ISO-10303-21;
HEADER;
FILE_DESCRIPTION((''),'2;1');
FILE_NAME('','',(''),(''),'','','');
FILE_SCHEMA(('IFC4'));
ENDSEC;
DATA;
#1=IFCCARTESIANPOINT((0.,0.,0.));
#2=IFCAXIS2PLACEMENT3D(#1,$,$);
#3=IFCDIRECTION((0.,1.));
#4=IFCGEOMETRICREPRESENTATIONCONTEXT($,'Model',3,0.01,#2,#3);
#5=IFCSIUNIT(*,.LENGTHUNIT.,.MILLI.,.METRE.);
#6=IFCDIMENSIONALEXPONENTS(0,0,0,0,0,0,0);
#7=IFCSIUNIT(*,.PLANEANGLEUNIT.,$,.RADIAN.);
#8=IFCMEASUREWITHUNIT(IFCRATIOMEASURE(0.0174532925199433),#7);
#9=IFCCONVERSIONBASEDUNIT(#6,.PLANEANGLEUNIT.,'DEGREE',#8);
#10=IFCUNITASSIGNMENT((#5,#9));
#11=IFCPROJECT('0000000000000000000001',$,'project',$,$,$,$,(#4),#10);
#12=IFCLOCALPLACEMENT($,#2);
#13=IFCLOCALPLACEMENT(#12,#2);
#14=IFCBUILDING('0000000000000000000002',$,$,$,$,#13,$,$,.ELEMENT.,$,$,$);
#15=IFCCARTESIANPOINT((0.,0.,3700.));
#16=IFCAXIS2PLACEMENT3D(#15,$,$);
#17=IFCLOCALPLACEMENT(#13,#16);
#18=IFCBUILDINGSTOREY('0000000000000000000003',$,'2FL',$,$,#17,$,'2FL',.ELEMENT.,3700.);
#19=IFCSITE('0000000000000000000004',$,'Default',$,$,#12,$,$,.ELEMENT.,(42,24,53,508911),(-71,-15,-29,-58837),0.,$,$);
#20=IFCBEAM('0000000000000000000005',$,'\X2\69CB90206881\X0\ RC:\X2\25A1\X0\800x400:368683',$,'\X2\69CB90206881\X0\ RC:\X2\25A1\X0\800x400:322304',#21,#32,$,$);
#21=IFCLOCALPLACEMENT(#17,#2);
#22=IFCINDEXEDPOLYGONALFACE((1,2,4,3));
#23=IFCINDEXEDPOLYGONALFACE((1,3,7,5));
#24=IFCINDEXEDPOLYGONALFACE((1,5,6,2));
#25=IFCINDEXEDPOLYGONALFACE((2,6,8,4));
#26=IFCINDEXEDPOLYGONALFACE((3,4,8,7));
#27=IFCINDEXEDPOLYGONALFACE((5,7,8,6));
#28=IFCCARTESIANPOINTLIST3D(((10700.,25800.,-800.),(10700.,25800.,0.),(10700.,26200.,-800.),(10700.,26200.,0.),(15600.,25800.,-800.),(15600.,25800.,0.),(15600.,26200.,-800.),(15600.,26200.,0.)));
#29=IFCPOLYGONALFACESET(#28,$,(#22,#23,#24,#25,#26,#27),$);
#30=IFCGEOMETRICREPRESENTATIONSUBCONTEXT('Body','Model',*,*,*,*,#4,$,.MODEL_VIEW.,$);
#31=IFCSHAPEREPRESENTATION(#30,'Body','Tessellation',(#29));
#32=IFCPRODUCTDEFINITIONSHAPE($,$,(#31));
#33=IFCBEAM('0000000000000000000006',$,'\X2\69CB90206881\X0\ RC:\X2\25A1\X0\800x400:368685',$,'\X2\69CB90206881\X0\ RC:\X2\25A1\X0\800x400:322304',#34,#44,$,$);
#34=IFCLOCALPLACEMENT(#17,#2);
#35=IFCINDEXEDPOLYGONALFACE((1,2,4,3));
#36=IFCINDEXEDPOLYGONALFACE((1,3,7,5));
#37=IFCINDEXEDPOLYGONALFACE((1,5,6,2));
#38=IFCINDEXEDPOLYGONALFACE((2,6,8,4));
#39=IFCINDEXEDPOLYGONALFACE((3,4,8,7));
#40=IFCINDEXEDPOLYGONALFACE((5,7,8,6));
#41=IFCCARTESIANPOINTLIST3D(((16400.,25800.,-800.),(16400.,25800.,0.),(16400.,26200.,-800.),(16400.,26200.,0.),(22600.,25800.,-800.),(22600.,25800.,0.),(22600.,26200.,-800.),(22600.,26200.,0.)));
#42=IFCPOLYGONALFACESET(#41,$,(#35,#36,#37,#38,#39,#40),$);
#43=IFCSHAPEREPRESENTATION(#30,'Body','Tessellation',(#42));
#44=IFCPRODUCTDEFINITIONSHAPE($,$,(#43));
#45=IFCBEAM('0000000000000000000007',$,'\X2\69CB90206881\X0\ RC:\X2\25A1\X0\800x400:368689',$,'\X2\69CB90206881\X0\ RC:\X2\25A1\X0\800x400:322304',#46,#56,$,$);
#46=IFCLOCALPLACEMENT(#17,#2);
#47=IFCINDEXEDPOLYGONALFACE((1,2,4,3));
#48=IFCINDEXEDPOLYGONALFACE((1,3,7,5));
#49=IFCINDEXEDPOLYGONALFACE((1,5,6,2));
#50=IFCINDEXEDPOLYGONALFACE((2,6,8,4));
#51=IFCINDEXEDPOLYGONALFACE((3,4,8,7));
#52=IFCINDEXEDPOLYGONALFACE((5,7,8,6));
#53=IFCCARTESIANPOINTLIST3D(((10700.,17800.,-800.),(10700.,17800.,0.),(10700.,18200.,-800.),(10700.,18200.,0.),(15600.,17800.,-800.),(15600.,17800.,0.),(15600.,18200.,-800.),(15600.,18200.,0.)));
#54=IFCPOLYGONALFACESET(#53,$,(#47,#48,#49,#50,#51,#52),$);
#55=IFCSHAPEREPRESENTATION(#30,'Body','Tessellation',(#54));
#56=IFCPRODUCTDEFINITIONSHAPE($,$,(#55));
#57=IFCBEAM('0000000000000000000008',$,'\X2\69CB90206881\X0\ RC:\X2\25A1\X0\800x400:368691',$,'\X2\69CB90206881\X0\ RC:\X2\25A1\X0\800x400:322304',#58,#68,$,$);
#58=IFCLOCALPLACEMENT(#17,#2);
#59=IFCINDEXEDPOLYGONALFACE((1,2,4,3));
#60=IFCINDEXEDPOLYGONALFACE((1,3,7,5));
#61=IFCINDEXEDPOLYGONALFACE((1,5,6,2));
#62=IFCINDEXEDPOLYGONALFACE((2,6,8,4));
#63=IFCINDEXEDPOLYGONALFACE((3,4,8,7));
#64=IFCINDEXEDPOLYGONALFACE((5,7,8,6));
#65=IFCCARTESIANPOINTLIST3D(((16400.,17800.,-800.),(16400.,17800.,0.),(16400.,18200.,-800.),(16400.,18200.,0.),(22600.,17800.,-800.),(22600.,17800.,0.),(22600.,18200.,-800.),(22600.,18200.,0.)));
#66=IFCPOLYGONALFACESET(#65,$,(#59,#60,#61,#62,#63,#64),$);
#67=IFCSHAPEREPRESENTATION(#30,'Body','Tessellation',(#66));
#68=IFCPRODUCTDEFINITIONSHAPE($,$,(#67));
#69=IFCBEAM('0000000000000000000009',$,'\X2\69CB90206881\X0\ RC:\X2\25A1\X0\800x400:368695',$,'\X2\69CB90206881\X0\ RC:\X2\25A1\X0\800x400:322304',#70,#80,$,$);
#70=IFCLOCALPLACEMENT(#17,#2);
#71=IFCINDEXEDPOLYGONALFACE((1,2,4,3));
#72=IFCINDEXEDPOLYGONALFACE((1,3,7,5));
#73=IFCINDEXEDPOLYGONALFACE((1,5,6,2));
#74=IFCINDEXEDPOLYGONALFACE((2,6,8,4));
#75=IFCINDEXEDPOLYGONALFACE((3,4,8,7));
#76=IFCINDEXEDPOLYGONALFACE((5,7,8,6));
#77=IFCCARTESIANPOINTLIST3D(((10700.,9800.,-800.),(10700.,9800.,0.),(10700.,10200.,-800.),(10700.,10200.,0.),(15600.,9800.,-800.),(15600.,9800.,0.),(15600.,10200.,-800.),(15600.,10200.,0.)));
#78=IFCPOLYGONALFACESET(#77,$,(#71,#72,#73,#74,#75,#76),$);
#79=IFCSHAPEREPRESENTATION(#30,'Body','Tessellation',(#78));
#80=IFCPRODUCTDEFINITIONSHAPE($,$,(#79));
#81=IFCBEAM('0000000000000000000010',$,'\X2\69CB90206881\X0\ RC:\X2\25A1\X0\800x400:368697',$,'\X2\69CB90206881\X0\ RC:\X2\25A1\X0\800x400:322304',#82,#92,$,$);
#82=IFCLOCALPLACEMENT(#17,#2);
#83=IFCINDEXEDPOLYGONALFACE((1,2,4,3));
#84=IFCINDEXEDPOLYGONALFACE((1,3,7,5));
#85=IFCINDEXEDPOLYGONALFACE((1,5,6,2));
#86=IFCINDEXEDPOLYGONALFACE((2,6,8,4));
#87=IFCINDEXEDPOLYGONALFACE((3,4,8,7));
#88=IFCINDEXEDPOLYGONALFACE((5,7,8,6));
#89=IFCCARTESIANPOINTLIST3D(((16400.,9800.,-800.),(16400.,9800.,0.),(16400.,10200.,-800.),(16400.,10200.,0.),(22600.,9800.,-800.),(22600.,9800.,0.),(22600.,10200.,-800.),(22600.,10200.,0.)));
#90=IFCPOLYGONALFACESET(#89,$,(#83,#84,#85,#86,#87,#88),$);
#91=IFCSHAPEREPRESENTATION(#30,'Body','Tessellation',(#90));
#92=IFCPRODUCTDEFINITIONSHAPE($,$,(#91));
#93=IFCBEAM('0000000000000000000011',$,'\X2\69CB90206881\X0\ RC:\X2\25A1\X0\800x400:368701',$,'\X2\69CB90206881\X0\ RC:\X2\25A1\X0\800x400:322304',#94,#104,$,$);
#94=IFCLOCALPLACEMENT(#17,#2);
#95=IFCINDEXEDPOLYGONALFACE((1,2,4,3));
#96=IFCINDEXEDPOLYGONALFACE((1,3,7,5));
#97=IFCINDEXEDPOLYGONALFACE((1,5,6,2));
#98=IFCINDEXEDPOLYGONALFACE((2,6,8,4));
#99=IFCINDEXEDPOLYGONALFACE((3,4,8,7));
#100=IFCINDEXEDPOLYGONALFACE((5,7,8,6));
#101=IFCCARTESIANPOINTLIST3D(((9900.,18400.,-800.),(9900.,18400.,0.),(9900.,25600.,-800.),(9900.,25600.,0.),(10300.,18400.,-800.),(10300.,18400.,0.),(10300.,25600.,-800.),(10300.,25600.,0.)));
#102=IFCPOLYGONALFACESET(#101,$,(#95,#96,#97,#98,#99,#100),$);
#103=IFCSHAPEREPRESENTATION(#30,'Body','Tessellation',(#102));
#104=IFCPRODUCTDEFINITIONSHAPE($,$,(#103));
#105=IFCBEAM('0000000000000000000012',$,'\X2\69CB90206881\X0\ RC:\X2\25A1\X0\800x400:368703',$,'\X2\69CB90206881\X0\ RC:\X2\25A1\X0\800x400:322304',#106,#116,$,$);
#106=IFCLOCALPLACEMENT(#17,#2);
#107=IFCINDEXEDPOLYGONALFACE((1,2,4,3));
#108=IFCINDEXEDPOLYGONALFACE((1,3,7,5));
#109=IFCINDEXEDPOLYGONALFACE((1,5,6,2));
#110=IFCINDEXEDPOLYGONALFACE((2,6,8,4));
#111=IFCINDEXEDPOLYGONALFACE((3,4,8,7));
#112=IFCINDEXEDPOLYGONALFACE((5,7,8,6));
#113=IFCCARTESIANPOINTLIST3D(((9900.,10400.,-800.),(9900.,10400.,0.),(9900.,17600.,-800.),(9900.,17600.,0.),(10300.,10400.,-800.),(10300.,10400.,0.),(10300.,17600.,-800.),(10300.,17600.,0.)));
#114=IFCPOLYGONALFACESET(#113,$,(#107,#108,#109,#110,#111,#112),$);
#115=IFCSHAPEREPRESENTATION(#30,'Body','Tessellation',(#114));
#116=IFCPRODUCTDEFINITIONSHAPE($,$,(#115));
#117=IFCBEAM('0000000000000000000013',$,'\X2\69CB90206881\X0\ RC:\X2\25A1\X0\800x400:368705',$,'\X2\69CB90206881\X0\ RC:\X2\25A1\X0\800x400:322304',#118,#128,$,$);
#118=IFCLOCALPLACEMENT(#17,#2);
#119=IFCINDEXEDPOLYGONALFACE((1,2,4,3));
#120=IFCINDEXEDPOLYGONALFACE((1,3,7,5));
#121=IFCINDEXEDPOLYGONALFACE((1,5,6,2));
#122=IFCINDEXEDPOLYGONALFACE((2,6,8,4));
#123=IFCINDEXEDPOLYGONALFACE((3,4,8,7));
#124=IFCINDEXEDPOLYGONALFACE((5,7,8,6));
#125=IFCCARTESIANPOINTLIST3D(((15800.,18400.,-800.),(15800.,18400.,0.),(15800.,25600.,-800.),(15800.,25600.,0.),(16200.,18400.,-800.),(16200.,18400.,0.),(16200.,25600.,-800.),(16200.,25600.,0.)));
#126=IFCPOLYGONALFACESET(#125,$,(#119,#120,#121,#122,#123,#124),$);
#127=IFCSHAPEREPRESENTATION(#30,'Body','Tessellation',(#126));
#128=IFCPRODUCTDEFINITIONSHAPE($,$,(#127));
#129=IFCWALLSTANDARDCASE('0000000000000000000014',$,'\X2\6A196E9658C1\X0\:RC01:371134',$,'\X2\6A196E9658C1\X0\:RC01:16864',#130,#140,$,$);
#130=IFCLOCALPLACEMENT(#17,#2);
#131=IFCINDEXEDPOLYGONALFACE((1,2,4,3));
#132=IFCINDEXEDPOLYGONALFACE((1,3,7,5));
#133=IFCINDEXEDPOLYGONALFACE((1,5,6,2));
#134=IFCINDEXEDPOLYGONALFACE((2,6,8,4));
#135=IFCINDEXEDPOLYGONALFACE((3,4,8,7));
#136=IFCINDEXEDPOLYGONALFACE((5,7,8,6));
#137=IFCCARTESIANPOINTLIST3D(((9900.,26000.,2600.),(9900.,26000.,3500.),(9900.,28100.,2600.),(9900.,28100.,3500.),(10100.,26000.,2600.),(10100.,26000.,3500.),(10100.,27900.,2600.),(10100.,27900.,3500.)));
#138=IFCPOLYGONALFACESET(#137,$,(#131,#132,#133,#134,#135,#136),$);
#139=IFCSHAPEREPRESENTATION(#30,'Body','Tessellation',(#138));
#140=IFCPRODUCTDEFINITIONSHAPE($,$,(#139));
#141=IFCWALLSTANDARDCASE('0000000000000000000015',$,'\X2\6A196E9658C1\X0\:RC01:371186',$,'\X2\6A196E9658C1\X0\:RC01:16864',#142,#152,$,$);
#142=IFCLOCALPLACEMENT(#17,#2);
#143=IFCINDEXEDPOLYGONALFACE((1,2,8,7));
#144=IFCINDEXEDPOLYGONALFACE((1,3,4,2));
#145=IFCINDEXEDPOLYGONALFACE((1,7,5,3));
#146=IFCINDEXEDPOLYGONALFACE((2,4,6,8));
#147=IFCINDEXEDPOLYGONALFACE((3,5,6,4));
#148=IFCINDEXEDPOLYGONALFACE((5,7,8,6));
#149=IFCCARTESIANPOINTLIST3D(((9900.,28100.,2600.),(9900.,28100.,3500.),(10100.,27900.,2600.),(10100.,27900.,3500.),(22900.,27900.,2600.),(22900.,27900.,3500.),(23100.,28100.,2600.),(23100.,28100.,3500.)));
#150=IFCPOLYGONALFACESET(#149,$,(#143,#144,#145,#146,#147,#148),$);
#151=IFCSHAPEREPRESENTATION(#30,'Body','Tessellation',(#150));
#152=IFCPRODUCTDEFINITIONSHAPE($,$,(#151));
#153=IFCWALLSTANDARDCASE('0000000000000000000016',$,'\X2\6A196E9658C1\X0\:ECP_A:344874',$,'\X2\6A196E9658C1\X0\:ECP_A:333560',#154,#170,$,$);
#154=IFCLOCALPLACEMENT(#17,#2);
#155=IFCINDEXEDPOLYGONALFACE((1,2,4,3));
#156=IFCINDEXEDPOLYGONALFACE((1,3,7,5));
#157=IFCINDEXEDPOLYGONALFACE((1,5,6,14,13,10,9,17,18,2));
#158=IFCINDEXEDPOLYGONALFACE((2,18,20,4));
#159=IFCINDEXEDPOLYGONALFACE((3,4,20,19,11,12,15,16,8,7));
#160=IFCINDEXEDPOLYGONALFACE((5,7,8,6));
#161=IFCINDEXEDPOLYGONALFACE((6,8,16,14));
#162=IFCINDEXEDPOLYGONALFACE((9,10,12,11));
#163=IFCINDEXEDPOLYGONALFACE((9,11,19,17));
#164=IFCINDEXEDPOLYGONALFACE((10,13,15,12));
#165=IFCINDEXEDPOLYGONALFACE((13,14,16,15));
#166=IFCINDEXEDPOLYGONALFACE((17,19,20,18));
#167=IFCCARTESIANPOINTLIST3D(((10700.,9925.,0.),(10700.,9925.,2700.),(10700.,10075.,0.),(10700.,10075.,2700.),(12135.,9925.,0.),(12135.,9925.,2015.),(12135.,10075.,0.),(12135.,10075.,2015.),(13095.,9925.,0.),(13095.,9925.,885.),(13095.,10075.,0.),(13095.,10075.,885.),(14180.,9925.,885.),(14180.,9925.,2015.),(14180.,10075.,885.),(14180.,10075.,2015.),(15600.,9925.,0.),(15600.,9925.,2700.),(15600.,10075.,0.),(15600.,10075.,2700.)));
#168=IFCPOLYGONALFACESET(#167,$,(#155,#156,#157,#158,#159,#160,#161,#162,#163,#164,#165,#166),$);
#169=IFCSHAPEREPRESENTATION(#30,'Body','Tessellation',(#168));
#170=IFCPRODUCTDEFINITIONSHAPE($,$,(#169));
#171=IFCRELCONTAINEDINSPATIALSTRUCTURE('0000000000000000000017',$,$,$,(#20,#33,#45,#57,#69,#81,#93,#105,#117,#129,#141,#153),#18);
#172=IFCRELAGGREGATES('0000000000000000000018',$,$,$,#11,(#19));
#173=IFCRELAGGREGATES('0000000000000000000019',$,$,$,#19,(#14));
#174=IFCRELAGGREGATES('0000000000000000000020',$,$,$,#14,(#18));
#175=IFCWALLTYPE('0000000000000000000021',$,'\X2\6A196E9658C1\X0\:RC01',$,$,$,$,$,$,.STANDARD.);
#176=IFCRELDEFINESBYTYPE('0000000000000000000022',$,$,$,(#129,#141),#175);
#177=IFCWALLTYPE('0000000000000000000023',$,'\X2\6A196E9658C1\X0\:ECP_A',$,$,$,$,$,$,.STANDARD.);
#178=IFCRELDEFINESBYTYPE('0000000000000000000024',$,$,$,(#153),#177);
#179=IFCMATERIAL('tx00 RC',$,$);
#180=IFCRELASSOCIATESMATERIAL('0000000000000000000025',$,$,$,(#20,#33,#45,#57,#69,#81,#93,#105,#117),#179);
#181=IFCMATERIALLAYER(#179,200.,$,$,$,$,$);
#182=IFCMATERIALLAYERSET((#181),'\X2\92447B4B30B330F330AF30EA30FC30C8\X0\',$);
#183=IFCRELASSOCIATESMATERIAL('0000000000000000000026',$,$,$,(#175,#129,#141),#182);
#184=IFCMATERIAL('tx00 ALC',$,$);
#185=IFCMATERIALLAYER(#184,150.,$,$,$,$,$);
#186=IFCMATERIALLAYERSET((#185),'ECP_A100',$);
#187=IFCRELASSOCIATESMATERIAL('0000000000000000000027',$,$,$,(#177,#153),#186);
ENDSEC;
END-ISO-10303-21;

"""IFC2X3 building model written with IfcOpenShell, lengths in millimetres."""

from ifc_helpers import new_model, entity, si_unit, converted_unit, direction, frame, frame_2d, origin, place, context, subcontext, project, spatial, polyline, rectangle, outline, extrude, material, layer, layer_set, layer_usage, type_object, element, save


model = new_model("IFC2X3")

# Units and contexts
model_context = context("Model", 3, precision=0.01, world=origin(), true_north=direction((0.0, 1.0)))
body_context = subcontext(model_context, "Body", "Model", "MODEL_VIEW")
ifc_project = project(units=[si_unit("LENGTHUNIT", "METRE", prefix="MILLI"), converted_unit("PLANEANGLEUNIT", "DEGREE", entity("IfcRatioMeasure", 0.0174532925199433), si_unit("PLANEANGLEUNIT", "RADIAN"), dimensions=[0, 0, 0, 0, 0, 0, 0])], contexts=[model_context])

# Site, building, storey
site_placement = place(None, origin())
site = spatial("IfcSite", under=ifc_project, at=site_placement, Name="Default", CompositionType="ELEMENT", RefLatitude=(42, 24, 53, 508911), RefLongitude=(-71, -15, -29, -58837), RefElevation=0.0)
building_placement = place(site_placement, origin())
building = spatial("IfcBuilding", under=site, at=building_placement, CompositionType="ELEMENT")
storey_placement = place(building_placement, frame((0.0, 0.0, 3700.0)))
storey = spatial("IfcBuildingStorey", under=building, at=storey_placement, Name="2FL", LongName="2FL", CompositionType="ELEMENT", Elevation=3700.0)

# Shared definitions
ifc_material_1 = material(Name="tx00 RC")

# Beams
beam_1_placement = place(storey_placement, frame((10300.0, 26000.0, 0.0)))
element("IfcBeam", 1, at=beam_1_placement, inside=storey, material=ifc_material_1, Name="構造梁 RC:□800x400:368683", ObjectType="構造梁 RC:□800x400:322304", context=body_context, shape_type="SweptSolid", body=[
    extrude(rectangle(XDim=800.0, YDim=400.0, at=frame_2d((0.0, 0.0), x_axis=(1.0, 0.0))), frame((400.0, 0.0, -400.0), z_axis=(1.0, 0.0, 0.0), x_axis=(0.0, 0.0, -1.0)), (0.0, 0.0, 1.0), 4900.0),
])
beam_2_placement = place(storey_placement, frame((16000.0, 26000.0, 0.0)))
element("IfcBeam", 2, at=beam_2_placement, inside=storey, material=ifc_material_1, Name="構造梁 RC:□800x400:368685", ObjectType="構造梁 RC:□800x400:322304", context=body_context, shape_type="SweptSolid", body=[
    extrude(rectangle(XDim=800.0, YDim=400.0, at=frame_2d((0.0, 0.0), x_axis=(1.0, 0.0))), frame((400.0, 0.0, -400.0), z_axis=(1.0, 0.0, 0.0), x_axis=(0.0, 0.0, -1.0)), (0.0, 0.0, 1.0), 6200.0),
])
beam_3_placement = place(storey_placement, frame((10300.0, 18000.0, 0.0)))
element("IfcBeam", 3, at=beam_3_placement, inside=storey, material=ifc_material_1, Name="構造梁 RC:□800x400:368689", ObjectType="構造梁 RC:□800x400:322304", context=body_context, shape_type="SweptSolid", body=[
    extrude(rectangle(XDim=800.0, YDim=400.0, at=frame_2d((0.0, 0.0), x_axis=(1.0, 0.0))), frame((400.0, 0.0, -400.0), z_axis=(1.0, 0.0, 0.0), x_axis=(0.0, 0.0, -1.0)), (0.0, 0.0, 1.0), 4900.0),
])
beam_4_placement = place(storey_placement, frame((16000.0, 18000.0, 0.0)))
element("IfcBeam", 4, at=beam_4_placement, inside=storey, material=ifc_material_1, Name="構造梁 RC:□800x400:368691", ObjectType="構造梁 RC:□800x400:322304", context=body_context, shape_type="SweptSolid", body=[
    extrude(rectangle(XDim=800.0, YDim=400.0, at=frame_2d((0.0, 0.0), x_axis=(1.0, 0.0))), frame((400.0, 0.0, -400.0), z_axis=(1.0, 0.0, 0.0), x_axis=(0.0, 0.0, -1.0)), (0.0, 0.0, 1.0), 6200.0),
])
beam_5_placement = place(storey_placement, frame((10300.0, 10000.0, 0.0)))
element("IfcBeam", 5, at=beam_5_placement, inside=storey, material=ifc_material_1, Name="構造梁 RC:□800x400:368695", ObjectType="構造梁 RC:□800x400:322304", context=body_context, shape_type="SweptSolid", body=[
    extrude(rectangle(XDim=800.0, YDim=400.0, at=frame_2d((0.0, 0.0), x_axis=(1.0, 0.0))), frame((400.0, 0.0, -400.0), z_axis=(1.0, 0.0, 0.0), x_axis=(0.0, 0.0, -1.0)), (0.0, 0.0, 1.0), 4900.0),
])
beam_6_placement = place(storey_placement, frame((16000.0, 10000.0, 0.0)))
element("IfcBeam", 6, at=beam_6_placement, inside=storey, material=ifc_material_1, Name="構造梁 RC:□800x400:368697", ObjectType="構造梁 RC:□800x400:322304", context=body_context, shape_type="SweptSolid", body=[
    extrude(rectangle(XDim=800.0, YDim=400.0, at=frame_2d((0.0, 0.0), x_axis=(1.0, 0.0))), frame((400.0, 0.0, -400.0), z_axis=(1.0, 0.0, 0.0), x_axis=(0.0, 0.0, -1.0)), (0.0, 0.0, 1.0), 6200.0),
])
for number, where, z_axis, x_axis, name in (
    (7, (10100.0, 26000.0, 0.0), (0.0, 0.0, 1.0), (0.0, -1.0, 0.0), "構造梁 RC:□800x400:368701"),
    (8, (10100.0, 18000.0, 0.0), (0.0, 0.0, 1.0), (0.0, -1.0, 0.0), "構造梁 RC:□800x400:368703"),
    (9, (16000.0, 26000.0, 0.0), (0.0, 0.0, 1.0), (0.0, -1.0, 0.0), "構造梁 RC:□800x400:368705"),
):
    element("IfcBeam", number, at=place(storey_placement, frame(where, z_axis=z_axis, x_axis=x_axis)), inside=storey, material=ifc_material_1, Name=name, ObjectType="構造梁 RC:□800x400:322304", context=body_context, shape_type="SweptSolid", body=[
        extrude(rectangle(XDim=800.0, YDim=400.0, at=frame_2d((0.0, 0.0), x_axis=(1.0, 0.0))), frame((400.0, 0.0, -400.0), z_axis=(1.0, 0.0, 0.0), x_axis=(0.0, 0.0, -1.0)), (0.0, 0.0, 1.0), 7200.0),
    ])

# Walls
ifc_layer_1 = layer(ifc_material_1, 200.0)
ifc_layer_set_1 = layer_set([ifc_layer_1], Name="鉄筋コンクリート")
ifc_layer_usage_1 = layer_usage(ifc_layer_set_1, "AXIS2", "NEGATIVE", 100.0)
wall_type_1 = type_object("IfcWallType", Name="標準壁:RC01", PredefinedType="STANDARD", material=ifc_layer_set_1)
wall_1_placement = place(storey_placement, frame((10000.0, 26000.0, 2600.0), z_axis=(0.0, 0.0, 1.0), x_axis=(0.0, 1.0, 0.0)))
element("IfcWallStandardCase", 10, at=wall_1_placement, inside=storey, type_object=wall_type_1, material=ifc_layer_usage_1, Name="標準壁:RC01:371134", ObjectType="標準壁:RC01:16864", context=body_context, shape_type="SweptSolid", body=[
    extrude(outline(polyline([(1900.0, -100.0), (2100.0, 100.0), (0.0, 100.0), (0.0, -100.0), (1900.0, -100.0)])), origin(), (0.0, 0.0, 1.0), 900.0),
])
ifc_layer_usage_2 = layer_usage(ifc_layer_set_1, "AXIS2", "NEGATIVE", 100.0)
wall_2_placement = place(storey_placement, frame((9900.0, 28000.0, 2600.0)))
element("IfcWallStandardCase", 11, at=wall_2_placement, inside=storey, type_object=wall_type_1, material=ifc_layer_usage_2, Name="標準壁:RC01:371186", ObjectType="標準壁:RC01:16864", context=body_context, shape_type="SweptSolid", body=[
    extrude(outline(polyline([(13000.0, -100.0), (13200.0, 100.0), (0.0, 100.0), (200.0, -100.0), (13000.0, -100.0)])), origin(), (0.0, 0.0, 1.0), 900.0),
])

# Wall, opening
ifc_material_2 = material(Name="tx00 ALC")
ifc_layer_2 = layer(ifc_material_2, 150.0)
ifc_layer_set_2 = layer_set([ifc_layer_2], Name="ECP_A100")
ifc_layer_usage_3 = layer_usage(ifc_layer_set_2, "AXIS2", "NEGATIVE", 75.0)
wall_type_2 = type_object("IfcWallType", Name="標準壁:ECP_A", PredefinedType="STANDARD", material=ifc_layer_set_2)
wall_3_placement = place(storey_placement, frame((10700.0, 10000.0, 0.0)))
wall_3 = element("IfcWallStandardCase", 12, at=wall_3_placement, inside=storey, type_object=wall_type_2, material=ifc_layer_usage_3, Name="標準壁:ECP_A:344874", ObjectType="標準壁:ECP_A:333560", context=body_context, shape_type="SweptSolid", body=[
    extrude(rectangle(XDim=4900.0, YDim=150.0, at=frame_2d((2450.0, 0.0), x_axis=(-1.0, 0.0))), origin(), (0.0, 0.0, 1.0), 2700.0),
])
opening_1_placement = place(wall_3_placement, frame((3480.0, 75.0, 0.0)))
element("IfcOpeningElement", 13, at=opening_1_placement, cuts=wall_3, ObjectType="Opening", context=body_context, shape_type="SweptSolid", body=[
    extrude(outline(polyline([(0.0, 2045.0), (0.0, 1085.0), (885.0, 1085.0), (885.0, 0.0), (2015.0, 0.0), (2015.0, 2045.0), (0.0, 2045.0)])), frame((0.0, 0.0, 0.0), z_axis=(0.0, -1.0, 0.0), x_axis=(0.0, 0.0, 1.0)), (0.0, 0.0, 1.0), 150.0),
])

save(model, "model.ifc")
